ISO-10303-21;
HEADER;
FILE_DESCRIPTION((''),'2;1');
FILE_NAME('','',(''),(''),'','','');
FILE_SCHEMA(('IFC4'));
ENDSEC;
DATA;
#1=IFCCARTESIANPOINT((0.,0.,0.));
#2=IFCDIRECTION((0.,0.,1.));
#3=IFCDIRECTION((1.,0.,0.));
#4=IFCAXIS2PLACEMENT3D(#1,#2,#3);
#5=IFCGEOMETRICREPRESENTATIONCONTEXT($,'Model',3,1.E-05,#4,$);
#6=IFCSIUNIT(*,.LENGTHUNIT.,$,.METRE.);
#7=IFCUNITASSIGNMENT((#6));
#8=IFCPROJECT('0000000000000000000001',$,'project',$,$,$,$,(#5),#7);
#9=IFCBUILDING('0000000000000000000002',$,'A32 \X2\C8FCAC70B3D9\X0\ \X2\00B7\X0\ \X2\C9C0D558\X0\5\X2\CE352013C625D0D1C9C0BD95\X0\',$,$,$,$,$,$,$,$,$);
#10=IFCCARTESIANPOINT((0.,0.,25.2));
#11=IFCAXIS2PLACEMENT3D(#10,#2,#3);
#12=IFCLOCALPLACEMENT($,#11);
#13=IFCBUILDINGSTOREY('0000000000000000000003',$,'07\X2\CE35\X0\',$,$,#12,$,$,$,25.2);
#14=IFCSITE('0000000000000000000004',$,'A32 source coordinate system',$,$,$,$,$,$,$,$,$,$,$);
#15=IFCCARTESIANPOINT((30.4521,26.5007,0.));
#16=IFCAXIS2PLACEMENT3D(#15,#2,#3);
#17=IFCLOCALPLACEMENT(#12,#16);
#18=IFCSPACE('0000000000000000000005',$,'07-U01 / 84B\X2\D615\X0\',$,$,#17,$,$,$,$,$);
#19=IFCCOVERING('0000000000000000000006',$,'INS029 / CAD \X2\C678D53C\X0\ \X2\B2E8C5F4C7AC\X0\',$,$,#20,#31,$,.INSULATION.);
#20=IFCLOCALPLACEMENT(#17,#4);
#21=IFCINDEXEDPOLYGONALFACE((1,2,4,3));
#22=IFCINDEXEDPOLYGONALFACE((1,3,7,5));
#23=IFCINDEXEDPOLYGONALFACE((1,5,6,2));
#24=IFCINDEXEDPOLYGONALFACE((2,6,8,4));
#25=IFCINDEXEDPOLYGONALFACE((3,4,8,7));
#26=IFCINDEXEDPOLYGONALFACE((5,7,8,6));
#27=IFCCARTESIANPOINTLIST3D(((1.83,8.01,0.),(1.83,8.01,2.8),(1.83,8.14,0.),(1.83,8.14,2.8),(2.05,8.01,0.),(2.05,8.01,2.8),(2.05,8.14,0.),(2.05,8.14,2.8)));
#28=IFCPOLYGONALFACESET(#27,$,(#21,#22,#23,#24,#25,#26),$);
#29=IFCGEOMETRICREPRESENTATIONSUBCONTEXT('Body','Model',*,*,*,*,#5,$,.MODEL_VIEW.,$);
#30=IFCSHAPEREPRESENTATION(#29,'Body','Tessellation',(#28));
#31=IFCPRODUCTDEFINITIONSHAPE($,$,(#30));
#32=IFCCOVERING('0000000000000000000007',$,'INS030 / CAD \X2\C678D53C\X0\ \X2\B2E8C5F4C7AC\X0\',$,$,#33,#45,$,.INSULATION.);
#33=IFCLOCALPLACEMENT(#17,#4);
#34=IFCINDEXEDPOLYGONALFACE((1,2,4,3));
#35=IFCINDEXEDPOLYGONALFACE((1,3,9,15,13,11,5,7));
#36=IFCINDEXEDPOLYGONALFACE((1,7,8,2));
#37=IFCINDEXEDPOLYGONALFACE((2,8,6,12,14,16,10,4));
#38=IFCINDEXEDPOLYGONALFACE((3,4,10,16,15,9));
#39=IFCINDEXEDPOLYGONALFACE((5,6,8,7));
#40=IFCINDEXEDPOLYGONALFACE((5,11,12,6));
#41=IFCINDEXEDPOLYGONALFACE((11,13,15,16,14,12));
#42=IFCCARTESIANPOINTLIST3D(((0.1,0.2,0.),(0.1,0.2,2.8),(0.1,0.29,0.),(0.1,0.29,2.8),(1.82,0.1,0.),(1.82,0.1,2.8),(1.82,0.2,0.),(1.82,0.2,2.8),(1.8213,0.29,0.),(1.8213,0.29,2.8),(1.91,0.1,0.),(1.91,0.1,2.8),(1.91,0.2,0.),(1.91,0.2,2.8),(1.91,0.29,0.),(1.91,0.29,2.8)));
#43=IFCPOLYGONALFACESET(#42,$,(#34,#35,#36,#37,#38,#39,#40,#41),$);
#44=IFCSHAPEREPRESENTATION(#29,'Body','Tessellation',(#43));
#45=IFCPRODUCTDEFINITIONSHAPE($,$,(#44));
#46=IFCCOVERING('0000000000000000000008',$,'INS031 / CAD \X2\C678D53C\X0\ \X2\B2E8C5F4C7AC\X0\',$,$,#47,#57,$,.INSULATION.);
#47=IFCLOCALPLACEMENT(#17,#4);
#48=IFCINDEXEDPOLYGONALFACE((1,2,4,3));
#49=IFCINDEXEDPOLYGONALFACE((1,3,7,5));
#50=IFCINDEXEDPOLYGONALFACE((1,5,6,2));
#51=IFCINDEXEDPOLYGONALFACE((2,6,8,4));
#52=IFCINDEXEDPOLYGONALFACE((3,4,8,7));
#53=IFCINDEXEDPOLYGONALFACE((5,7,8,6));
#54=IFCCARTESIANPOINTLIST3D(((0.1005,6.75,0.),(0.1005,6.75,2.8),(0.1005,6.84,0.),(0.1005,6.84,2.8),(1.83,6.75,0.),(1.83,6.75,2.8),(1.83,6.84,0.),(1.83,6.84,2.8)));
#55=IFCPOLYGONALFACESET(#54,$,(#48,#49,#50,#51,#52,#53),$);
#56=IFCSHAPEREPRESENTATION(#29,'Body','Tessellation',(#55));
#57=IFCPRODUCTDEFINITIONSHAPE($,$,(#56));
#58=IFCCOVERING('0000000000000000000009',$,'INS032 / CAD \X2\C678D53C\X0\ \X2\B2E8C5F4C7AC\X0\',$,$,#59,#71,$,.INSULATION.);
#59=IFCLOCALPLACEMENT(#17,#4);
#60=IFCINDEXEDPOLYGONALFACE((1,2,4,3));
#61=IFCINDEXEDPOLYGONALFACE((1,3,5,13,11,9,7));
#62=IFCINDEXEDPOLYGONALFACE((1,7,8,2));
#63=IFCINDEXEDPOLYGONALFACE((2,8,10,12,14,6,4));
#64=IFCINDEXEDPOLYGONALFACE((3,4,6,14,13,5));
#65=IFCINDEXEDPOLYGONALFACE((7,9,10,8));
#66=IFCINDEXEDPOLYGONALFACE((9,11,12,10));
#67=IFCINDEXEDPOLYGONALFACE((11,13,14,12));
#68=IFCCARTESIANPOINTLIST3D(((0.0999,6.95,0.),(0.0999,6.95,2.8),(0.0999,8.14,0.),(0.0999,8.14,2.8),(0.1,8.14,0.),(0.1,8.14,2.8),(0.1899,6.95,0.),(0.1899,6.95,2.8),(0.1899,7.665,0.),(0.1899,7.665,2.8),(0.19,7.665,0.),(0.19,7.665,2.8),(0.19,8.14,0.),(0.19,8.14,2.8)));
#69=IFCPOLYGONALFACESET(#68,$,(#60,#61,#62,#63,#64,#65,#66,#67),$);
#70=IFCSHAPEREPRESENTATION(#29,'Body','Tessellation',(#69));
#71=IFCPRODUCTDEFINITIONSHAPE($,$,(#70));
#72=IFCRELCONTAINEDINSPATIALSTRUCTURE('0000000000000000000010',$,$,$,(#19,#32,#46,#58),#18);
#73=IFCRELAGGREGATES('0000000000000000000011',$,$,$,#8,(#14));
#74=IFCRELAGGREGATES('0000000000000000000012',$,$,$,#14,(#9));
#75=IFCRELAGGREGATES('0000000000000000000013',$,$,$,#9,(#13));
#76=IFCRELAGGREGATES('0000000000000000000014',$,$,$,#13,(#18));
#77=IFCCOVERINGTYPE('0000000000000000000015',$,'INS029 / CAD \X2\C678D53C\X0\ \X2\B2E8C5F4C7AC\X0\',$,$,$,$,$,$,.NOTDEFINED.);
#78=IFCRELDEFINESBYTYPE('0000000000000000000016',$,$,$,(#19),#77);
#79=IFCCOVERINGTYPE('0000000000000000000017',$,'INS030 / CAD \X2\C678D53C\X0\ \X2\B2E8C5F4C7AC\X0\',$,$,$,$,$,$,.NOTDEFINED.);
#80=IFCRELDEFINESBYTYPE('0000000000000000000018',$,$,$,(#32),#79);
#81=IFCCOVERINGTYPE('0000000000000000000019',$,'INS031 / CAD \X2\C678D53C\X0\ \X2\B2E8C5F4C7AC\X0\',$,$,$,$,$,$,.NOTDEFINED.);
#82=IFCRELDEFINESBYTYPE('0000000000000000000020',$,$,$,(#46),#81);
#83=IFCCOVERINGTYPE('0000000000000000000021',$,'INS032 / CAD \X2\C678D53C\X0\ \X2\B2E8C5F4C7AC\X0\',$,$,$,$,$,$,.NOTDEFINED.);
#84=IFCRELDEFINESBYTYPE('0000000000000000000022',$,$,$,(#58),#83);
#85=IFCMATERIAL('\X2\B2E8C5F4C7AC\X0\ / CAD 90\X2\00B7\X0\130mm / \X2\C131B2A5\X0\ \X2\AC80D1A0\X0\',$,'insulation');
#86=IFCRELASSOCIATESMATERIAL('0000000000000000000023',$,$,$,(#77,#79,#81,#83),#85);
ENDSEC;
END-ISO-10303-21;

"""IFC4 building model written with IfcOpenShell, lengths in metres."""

from ifc_helpers import new_model, si_unit, frame, origin, origin_with_axes, place, context, subcontext, project, spatial, polyline, outline, extrude, source, transform, mapped, material, type_object, type_shapes, element, save


model = new_model("IFC4")

# Units and contexts
model_context = context("Model", 3, precision=1e-05, world=origin_with_axes())
body_context = subcontext(model_context, "Body", "Model", "MODEL_VIEW")
ifc_project = project(units=[si_unit("LENGTHUNIT", "METRE")], contexts=[model_context])

# Site, building, storey, space
storey_placement = place(None, frame((0.0, 0.0, 25.2), z_axis=(0.0, 0.0, 1.0), x_axis=(1.0, 0.0, 0.0)))
space_placement = place(storey_placement, frame((30.4521, 26.5007, 0.0), z_axis=(0.0, 0.0, 1.0), x_axis=(1.0, 0.0, 0.0)))
site = spatial("IfcSite", under=ifc_project, Name="A32 source coordinate system")
building = spatial("IfcBuilding", under=site, Name="A32 주거동 · 지하5층–옥탑지붕")
storey = spatial("IfcBuildingStorey", under=building, at=storey_placement, Name="07층", Elevation=25.2)
space = spatial("IfcSpace", under=storey, at=space_placement, Name="07-U01 / 84B형")

# Coverings
ifc_material = material(Name="단열재 / CAD 90·130mm / 성능 검토", Category="insulation")
covering_type_1 = type_object("IfcCoveringType", Name="INS029 / CAD 외피 단열재", PredefinedType="NOTDEFINED", material=ifc_material)
shared_shape_1 = source(origin(), body_context, "Body", "SweptSolid", [
    extrude(outline(polyline([(1.83, 8.01), (1.83, 8.14), (2.05, 8.14), (2.05, 8.01), (1.83, 8.01)])), origin(), (0.0, 0.0, 1.0), 2.8),
])
type_shapes(covering_type_1, [shared_shape_1])
covering_1_placement = place(space_placement, origin_with_axes())
element("IfcCovering", 1, at=covering_1_placement, inside=space, type_object=covering_type_1, Name="INS029 / CAD 외피 단열재", PredefinedType="INSULATION", context=body_context, shape_type="MappedRepresentation", body=[
    mapped(shared_shape_1, transform((0.0, 0.0, 0.0), scale=1.0)),
])
covering_type_2 = type_object("IfcCoveringType", Name="INS030 / CAD 외피 단열재", PredefinedType="NOTDEFINED", material=ifc_material)
shared_shape_2 = source(origin(), body_context, "Body", "SweptSolid", [
    extrude(outline(polyline([(1.91, 0.2), (1.91, 0.1), (1.82, 0.1), (1.82, 0.2), (0.1, 0.2), (0.1, 0.29), (1.8213, 0.29), (1.91, 0.29), (1.91, 0.2)])), origin(), (0.0, 0.0, 1.0), 2.8),
])
type_shapes(covering_type_2, [shared_shape_2])
covering_2_placement = place(space_placement, origin_with_axes())
element("IfcCovering", 2, at=covering_2_placement, inside=space, type_object=covering_type_2, Name="INS030 / CAD 외피 단열재", PredefinedType="INSULATION", context=body_context, shape_type="MappedRepresentation", body=[
    mapped(shared_shape_2, transform((0.0, 0.0, 0.0), scale=1.0)),
])
covering_type_3 = type_object("IfcCoveringType", Name="INS031 / CAD 외피 단열재", PredefinedType="NOTDEFINED", material=ifc_material)
shared_shape_3 = source(origin(), body_context, "Body", "SweptSolid", [
    extrude(outline(polyline([(1.83, 6.75), (0.1005, 6.75), (0.1005, 6.84), (1.83, 6.84), (1.83, 6.75)])), origin(), (0.0, 0.0, 1.0), 2.8),
])
type_shapes(covering_type_3, [shared_shape_3])
covering_3_placement = place(space_placement, origin_with_axes())
element("IfcCovering", 3, at=covering_3_placement, inside=space, type_object=covering_type_3, Name="INS031 / CAD 외피 단열재", PredefinedType="INSULATION", context=body_context, shape_type="MappedRepresentation", body=[
    mapped(shared_shape_3, transform((0.0, 0.0, 0.0), scale=1.0)),
])
covering_type_4 = type_object("IfcCoveringType", Name="INS032 / CAD 외피 단열재", PredefinedType="NOTDEFINED", material=ifc_material)
shared_shape_4 = source(origin(), body_context, "Body", "SweptSolid", [
    extrude(outline(polyline([(0.1899, 6.95), (0.0999, 6.95), (0.0999, 8.14), (0.1, 8.14), (0.19, 8.14), (0.19, 7.665), (0.1899, 7.665), (0.1899, 6.95)])), origin(), (0.0, 0.0, 1.0), 2.8),
])
type_shapes(covering_type_4, [shared_shape_4])
covering_4_placement = place(space_placement, origin_with_axes())
element("IfcCovering", 4, at=covering_4_placement, inside=space, type_object=covering_type_4, Name="INS032 / CAD 외피 단열재", PredefinedType="INSULATION", context=body_context, shape_type="MappedRepresentation", body=[
    mapped(shared_shape_4, transform((0.0, 0.0, 0.0), scale=1.0)),
])

save(model, "model.ifc")
